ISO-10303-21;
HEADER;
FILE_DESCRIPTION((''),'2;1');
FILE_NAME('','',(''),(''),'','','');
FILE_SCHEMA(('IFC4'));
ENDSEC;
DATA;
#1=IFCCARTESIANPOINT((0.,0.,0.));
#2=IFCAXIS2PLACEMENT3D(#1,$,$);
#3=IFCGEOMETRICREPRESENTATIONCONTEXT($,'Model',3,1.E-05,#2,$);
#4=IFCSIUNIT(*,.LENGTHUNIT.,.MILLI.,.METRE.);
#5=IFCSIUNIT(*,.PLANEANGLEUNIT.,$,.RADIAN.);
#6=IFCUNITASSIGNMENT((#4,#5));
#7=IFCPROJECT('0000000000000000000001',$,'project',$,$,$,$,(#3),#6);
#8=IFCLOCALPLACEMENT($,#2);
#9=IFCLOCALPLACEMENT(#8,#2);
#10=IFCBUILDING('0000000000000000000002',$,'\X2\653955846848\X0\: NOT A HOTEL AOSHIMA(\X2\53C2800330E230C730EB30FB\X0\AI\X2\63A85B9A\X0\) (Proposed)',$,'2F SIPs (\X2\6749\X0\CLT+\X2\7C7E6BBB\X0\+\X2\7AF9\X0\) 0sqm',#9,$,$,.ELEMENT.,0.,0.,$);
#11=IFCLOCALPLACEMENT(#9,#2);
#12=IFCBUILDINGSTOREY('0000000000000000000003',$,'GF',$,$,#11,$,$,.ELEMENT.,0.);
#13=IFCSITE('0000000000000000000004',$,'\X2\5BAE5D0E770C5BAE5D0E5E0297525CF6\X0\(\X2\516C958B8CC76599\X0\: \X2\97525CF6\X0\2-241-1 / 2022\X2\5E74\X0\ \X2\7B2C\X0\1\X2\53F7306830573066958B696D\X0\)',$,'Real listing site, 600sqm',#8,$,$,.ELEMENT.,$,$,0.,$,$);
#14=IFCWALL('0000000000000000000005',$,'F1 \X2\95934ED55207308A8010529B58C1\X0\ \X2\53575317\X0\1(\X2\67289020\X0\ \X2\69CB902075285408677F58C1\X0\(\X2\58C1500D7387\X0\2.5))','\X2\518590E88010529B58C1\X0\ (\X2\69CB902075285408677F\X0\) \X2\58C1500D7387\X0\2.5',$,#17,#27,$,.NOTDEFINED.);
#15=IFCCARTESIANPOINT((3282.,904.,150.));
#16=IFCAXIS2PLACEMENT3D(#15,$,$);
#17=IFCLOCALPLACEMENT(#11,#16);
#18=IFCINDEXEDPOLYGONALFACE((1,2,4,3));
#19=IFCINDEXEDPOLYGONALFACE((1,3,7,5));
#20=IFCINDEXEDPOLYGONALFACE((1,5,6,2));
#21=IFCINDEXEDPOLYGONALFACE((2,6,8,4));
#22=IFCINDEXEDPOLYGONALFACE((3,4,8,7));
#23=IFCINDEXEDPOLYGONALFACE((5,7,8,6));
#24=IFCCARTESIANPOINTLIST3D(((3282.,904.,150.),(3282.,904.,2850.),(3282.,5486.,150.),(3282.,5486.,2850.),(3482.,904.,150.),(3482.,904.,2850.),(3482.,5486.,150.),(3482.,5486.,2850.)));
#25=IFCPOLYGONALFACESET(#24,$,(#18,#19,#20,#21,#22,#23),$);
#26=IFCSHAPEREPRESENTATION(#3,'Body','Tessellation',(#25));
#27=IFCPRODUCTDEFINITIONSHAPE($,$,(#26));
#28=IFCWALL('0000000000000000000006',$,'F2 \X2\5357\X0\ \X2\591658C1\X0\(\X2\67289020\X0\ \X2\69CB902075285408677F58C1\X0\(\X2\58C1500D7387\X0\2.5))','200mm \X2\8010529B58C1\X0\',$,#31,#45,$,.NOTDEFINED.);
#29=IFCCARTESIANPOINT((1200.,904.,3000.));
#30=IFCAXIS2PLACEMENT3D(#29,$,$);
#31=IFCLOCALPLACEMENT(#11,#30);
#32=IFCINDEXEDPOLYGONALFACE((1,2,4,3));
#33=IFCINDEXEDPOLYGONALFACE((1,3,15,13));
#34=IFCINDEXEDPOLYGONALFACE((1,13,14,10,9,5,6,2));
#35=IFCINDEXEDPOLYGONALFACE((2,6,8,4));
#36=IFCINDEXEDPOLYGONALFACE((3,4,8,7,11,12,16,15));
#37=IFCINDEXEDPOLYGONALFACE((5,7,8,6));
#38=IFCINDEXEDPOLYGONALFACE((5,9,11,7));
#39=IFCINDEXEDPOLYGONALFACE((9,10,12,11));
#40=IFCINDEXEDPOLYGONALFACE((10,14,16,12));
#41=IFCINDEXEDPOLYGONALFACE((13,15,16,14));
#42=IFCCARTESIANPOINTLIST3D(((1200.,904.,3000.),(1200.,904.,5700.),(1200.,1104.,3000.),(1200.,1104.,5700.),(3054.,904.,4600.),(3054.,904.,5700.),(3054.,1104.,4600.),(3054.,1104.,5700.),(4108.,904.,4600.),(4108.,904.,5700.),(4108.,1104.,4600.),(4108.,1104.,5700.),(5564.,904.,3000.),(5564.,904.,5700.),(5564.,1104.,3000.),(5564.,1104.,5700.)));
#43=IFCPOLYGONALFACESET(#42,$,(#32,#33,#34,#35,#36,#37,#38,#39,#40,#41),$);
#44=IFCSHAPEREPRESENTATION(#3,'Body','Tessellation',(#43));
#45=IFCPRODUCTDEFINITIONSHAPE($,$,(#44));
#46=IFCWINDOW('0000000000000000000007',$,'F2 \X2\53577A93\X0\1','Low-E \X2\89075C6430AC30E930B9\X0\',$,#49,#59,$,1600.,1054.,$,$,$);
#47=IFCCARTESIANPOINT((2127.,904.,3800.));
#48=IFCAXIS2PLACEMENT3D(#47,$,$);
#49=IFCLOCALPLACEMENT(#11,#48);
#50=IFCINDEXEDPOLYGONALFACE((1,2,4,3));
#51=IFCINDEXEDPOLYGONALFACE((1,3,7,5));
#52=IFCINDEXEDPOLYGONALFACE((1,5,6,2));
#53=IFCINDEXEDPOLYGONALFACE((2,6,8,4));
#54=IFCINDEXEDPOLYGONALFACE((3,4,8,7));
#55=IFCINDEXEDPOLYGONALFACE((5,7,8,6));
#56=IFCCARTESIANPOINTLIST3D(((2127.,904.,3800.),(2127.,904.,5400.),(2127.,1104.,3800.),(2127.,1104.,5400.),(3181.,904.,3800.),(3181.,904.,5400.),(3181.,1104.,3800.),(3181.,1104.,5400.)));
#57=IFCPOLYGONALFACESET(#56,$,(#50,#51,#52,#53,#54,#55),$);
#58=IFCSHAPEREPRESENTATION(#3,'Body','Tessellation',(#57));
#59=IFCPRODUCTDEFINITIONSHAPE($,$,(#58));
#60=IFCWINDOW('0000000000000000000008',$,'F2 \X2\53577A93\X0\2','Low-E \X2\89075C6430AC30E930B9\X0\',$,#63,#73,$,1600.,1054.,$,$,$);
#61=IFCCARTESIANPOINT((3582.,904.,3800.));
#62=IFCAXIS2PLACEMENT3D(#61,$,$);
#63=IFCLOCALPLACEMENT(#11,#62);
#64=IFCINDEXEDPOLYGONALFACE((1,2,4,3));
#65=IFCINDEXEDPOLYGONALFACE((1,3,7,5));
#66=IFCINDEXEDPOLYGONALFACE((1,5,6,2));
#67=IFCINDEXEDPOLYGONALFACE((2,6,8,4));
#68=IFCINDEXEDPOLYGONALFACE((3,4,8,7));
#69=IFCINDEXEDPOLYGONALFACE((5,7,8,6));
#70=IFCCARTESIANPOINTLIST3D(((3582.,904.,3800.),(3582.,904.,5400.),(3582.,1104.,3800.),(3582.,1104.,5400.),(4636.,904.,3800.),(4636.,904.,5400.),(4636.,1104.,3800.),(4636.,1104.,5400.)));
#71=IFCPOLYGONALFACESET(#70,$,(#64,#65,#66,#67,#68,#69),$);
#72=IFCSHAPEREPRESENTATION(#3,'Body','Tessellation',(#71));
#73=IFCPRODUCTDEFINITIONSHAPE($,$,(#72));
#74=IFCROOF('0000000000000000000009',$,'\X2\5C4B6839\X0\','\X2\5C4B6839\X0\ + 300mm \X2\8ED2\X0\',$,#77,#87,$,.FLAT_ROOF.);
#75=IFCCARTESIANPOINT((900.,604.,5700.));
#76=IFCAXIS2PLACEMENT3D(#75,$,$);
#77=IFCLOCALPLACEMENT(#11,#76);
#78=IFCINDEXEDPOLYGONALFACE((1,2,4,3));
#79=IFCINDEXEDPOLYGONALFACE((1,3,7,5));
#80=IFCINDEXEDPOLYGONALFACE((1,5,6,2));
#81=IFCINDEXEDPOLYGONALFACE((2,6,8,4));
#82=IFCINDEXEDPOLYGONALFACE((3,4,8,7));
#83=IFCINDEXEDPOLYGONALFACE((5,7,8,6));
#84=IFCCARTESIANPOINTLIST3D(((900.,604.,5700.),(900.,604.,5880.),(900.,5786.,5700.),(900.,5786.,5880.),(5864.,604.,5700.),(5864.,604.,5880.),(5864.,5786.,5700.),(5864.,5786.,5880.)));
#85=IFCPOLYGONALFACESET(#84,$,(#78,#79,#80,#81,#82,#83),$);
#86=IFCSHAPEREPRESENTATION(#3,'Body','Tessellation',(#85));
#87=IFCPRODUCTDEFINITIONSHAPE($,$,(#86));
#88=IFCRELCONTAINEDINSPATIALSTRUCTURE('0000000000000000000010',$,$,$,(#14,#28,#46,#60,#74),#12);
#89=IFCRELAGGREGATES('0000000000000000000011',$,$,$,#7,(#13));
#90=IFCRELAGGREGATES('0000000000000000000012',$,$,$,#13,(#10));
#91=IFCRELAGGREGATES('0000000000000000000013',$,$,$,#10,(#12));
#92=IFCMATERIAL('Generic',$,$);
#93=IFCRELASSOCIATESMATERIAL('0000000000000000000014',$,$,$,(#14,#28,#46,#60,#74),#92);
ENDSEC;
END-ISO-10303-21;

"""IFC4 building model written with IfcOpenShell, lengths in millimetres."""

from ifc_helpers import new_model, si_unit, frame, frame_2d, origin, place, context, project, spatial, rectangle, extrude, material, element, fill, save


model = new_model("IFC4")

# Units and contexts
model_context = context("Model", 3, precision=1e-05, world=origin())
ifc_project = project(units=[si_unit("LENGTHUNIT", "METRE", prefix="MILLI"), si_unit("PLANEANGLEUNIT", "RADIAN")], contexts=[model_context])

# Site, building, storey
site_placement = place(None, origin())
site = spatial("IfcSite", under=ifc_project, at=site_placement, Name="宮崎県宮崎市青島(公開資料: 青島2-241-1 / 2022年 第1号として開業)", ObjectType="Real listing site, 600sqm", CompositionType="ELEMENT", RefElevation=0.0)
building_placement = place(site_placement, origin())
building = spatial("IfcBuilding", under=site, at=building_placement, Name="改善案: NOT A HOTEL AOSHIMA(参考モデル・AI推定) (Proposed)", ObjectType="2F SIPs (杉CLT+籾殻+竹) 0sqm", CompositionType="ELEMENT", ElevationOfRefHeight=0.0, ElevationOfTerrain=0.0)
storey_placement = place(building_placement, origin())
storey = spatial("IfcBuildingStorey", under=building, at=storey_placement, Name="GF", CompositionType="ELEMENT", Elevation=0.0)

# Shared definitions
ifc_material_1 = material(Name="Generic")

# Wall
wall_1_placement = place(storey_placement, frame((3282.0, 904.0, 150.0)))
element("IfcWall", 1, at=wall_1_placement, inside=storey, material=ifc_material_1, Name="F1 間仕切り耐力壁 南北1(木造 構造用合板壁(壁倍率2.5))", Description="内部耐力壁 (構造用合板) 壁倍率2.5", PredefinedType="NOTDEFINED", context=model_context, shape_type="SweptSolid", body=[
    extrude(rectangle(XDim=200.0, YDim=4582.0, at=frame_2d((100.0, 2291.0))), frame((3282.0, 904.0, 150.0)), (0.0, 0.0, 1.0), 2700.0),
])

# Wall, openings, windows
wall_2_placement = place(storey_placement, frame((1200.0, 904.0, 3000.0)))
wall_2 = element("IfcWall", 2, at=wall_2_placement, inside=storey, material=ifc_material_1, Name="F2 南 外壁(木造 構造用合板壁(壁倍率2.5))", Description="200mm 耐力壁", PredefinedType="NOTDEFINED", context=model_context, shape_type="SweptSolid", body=[
    extrude(rectangle(XDim=4364.0, YDim=200.0, at=frame_2d((2182.0, 100.0))), frame((1200.0, 904.0, 3000.0)), (0.0, 0.0, 1.0), 2700.0),
])
opening_1_placement = place(storey_placement, frame((2127.0, 904.0, 3800.0)))
opening_1 = element("IfcOpeningElement", 3, at=opening_1_placement, cuts=wall_2, PredefinedType="NOTDEFINED", context=model_context, shape_type="SweptSolid", body=[
    extrude(rectangle(XDim=1054.0, YDim=200.0, at=frame_2d((527.0, 100.0))), frame((2127.0, 904.0, 3800.0)), (0.0, 0.0, 1.0), 1600.0),
])
opening_2_placement = place(storey_placement, frame((3582.0, 904.0, 3800.0)))
opening_2 = element("IfcOpeningElement", 4, at=opening_2_placement, cuts=wall_2, PredefinedType="NOTDEFINED", context=model_context, shape_type="SweptSolid", body=[
    extrude(rectangle(XDim=1054.0, YDim=200.0, at=frame_2d((527.0, 100.0))), frame((3582.0, 904.0, 3800.0)), (0.0, 0.0, 1.0), 1600.0),
])
window_1_placement = place(storey_placement, frame((2127.0, 904.0, 3800.0)))
window_1 = element("IfcWindow", 5, at=window_1_placement, inside=storey, material=ifc_material_1, Name="F2 南窓1", Description="Low-E 複層ガラス", OverallHeight=1600.0, OverallWidth=1054.0, context=model_context, shape_type="SweptSolid", body=[
    extrude(rectangle(XDim=1054.0, YDim=200.0, at=frame_2d((527.0, 100.0))), frame((2127.0, 904.0, 3800.0)), (0.0, 0.0, 1.0), 1600.0),
])
fill(opening_1, window_1)
window_2_placement = place(storey_placement, frame((3582.0, 904.0, 3800.0)))
window_2 = element("IfcWindow", 6, at=window_2_placement, inside=storey, material=ifc_material_1, Name="F2 南窓2", Description="Low-E 複層ガラス", OverallHeight=1600.0, OverallWidth=1054.0, context=model_context, shape_type="SweptSolid", body=[
    extrude(rectangle(XDim=1054.0, YDim=200.0, at=frame_2d((527.0, 100.0))), frame((3582.0, 904.0, 3800.0)), (0.0, 0.0, 1.0), 1600.0),
])
fill(opening_2, window_2)

# Roof
roof_placement = place(storey_placement, frame((900.0, 604.0, 5700.0)))
element("IfcRoof", 7, at=roof_placement, inside=storey, material=ifc_material_1, Name="屋根", Description="屋根 + 300mm 軒", PredefinedType="FLAT_ROOF", context=model_context, shape_type="SweptSolid", body=[
    extrude(rectangle(XDim=4964.0, YDim=5182.0, at=frame_2d((2482.0, 2591.0))), frame((900.0, 604.0, 5700.0)), (0.0, 0.0, 1.0), 180.0),
])

save(model, "model.ifc")
